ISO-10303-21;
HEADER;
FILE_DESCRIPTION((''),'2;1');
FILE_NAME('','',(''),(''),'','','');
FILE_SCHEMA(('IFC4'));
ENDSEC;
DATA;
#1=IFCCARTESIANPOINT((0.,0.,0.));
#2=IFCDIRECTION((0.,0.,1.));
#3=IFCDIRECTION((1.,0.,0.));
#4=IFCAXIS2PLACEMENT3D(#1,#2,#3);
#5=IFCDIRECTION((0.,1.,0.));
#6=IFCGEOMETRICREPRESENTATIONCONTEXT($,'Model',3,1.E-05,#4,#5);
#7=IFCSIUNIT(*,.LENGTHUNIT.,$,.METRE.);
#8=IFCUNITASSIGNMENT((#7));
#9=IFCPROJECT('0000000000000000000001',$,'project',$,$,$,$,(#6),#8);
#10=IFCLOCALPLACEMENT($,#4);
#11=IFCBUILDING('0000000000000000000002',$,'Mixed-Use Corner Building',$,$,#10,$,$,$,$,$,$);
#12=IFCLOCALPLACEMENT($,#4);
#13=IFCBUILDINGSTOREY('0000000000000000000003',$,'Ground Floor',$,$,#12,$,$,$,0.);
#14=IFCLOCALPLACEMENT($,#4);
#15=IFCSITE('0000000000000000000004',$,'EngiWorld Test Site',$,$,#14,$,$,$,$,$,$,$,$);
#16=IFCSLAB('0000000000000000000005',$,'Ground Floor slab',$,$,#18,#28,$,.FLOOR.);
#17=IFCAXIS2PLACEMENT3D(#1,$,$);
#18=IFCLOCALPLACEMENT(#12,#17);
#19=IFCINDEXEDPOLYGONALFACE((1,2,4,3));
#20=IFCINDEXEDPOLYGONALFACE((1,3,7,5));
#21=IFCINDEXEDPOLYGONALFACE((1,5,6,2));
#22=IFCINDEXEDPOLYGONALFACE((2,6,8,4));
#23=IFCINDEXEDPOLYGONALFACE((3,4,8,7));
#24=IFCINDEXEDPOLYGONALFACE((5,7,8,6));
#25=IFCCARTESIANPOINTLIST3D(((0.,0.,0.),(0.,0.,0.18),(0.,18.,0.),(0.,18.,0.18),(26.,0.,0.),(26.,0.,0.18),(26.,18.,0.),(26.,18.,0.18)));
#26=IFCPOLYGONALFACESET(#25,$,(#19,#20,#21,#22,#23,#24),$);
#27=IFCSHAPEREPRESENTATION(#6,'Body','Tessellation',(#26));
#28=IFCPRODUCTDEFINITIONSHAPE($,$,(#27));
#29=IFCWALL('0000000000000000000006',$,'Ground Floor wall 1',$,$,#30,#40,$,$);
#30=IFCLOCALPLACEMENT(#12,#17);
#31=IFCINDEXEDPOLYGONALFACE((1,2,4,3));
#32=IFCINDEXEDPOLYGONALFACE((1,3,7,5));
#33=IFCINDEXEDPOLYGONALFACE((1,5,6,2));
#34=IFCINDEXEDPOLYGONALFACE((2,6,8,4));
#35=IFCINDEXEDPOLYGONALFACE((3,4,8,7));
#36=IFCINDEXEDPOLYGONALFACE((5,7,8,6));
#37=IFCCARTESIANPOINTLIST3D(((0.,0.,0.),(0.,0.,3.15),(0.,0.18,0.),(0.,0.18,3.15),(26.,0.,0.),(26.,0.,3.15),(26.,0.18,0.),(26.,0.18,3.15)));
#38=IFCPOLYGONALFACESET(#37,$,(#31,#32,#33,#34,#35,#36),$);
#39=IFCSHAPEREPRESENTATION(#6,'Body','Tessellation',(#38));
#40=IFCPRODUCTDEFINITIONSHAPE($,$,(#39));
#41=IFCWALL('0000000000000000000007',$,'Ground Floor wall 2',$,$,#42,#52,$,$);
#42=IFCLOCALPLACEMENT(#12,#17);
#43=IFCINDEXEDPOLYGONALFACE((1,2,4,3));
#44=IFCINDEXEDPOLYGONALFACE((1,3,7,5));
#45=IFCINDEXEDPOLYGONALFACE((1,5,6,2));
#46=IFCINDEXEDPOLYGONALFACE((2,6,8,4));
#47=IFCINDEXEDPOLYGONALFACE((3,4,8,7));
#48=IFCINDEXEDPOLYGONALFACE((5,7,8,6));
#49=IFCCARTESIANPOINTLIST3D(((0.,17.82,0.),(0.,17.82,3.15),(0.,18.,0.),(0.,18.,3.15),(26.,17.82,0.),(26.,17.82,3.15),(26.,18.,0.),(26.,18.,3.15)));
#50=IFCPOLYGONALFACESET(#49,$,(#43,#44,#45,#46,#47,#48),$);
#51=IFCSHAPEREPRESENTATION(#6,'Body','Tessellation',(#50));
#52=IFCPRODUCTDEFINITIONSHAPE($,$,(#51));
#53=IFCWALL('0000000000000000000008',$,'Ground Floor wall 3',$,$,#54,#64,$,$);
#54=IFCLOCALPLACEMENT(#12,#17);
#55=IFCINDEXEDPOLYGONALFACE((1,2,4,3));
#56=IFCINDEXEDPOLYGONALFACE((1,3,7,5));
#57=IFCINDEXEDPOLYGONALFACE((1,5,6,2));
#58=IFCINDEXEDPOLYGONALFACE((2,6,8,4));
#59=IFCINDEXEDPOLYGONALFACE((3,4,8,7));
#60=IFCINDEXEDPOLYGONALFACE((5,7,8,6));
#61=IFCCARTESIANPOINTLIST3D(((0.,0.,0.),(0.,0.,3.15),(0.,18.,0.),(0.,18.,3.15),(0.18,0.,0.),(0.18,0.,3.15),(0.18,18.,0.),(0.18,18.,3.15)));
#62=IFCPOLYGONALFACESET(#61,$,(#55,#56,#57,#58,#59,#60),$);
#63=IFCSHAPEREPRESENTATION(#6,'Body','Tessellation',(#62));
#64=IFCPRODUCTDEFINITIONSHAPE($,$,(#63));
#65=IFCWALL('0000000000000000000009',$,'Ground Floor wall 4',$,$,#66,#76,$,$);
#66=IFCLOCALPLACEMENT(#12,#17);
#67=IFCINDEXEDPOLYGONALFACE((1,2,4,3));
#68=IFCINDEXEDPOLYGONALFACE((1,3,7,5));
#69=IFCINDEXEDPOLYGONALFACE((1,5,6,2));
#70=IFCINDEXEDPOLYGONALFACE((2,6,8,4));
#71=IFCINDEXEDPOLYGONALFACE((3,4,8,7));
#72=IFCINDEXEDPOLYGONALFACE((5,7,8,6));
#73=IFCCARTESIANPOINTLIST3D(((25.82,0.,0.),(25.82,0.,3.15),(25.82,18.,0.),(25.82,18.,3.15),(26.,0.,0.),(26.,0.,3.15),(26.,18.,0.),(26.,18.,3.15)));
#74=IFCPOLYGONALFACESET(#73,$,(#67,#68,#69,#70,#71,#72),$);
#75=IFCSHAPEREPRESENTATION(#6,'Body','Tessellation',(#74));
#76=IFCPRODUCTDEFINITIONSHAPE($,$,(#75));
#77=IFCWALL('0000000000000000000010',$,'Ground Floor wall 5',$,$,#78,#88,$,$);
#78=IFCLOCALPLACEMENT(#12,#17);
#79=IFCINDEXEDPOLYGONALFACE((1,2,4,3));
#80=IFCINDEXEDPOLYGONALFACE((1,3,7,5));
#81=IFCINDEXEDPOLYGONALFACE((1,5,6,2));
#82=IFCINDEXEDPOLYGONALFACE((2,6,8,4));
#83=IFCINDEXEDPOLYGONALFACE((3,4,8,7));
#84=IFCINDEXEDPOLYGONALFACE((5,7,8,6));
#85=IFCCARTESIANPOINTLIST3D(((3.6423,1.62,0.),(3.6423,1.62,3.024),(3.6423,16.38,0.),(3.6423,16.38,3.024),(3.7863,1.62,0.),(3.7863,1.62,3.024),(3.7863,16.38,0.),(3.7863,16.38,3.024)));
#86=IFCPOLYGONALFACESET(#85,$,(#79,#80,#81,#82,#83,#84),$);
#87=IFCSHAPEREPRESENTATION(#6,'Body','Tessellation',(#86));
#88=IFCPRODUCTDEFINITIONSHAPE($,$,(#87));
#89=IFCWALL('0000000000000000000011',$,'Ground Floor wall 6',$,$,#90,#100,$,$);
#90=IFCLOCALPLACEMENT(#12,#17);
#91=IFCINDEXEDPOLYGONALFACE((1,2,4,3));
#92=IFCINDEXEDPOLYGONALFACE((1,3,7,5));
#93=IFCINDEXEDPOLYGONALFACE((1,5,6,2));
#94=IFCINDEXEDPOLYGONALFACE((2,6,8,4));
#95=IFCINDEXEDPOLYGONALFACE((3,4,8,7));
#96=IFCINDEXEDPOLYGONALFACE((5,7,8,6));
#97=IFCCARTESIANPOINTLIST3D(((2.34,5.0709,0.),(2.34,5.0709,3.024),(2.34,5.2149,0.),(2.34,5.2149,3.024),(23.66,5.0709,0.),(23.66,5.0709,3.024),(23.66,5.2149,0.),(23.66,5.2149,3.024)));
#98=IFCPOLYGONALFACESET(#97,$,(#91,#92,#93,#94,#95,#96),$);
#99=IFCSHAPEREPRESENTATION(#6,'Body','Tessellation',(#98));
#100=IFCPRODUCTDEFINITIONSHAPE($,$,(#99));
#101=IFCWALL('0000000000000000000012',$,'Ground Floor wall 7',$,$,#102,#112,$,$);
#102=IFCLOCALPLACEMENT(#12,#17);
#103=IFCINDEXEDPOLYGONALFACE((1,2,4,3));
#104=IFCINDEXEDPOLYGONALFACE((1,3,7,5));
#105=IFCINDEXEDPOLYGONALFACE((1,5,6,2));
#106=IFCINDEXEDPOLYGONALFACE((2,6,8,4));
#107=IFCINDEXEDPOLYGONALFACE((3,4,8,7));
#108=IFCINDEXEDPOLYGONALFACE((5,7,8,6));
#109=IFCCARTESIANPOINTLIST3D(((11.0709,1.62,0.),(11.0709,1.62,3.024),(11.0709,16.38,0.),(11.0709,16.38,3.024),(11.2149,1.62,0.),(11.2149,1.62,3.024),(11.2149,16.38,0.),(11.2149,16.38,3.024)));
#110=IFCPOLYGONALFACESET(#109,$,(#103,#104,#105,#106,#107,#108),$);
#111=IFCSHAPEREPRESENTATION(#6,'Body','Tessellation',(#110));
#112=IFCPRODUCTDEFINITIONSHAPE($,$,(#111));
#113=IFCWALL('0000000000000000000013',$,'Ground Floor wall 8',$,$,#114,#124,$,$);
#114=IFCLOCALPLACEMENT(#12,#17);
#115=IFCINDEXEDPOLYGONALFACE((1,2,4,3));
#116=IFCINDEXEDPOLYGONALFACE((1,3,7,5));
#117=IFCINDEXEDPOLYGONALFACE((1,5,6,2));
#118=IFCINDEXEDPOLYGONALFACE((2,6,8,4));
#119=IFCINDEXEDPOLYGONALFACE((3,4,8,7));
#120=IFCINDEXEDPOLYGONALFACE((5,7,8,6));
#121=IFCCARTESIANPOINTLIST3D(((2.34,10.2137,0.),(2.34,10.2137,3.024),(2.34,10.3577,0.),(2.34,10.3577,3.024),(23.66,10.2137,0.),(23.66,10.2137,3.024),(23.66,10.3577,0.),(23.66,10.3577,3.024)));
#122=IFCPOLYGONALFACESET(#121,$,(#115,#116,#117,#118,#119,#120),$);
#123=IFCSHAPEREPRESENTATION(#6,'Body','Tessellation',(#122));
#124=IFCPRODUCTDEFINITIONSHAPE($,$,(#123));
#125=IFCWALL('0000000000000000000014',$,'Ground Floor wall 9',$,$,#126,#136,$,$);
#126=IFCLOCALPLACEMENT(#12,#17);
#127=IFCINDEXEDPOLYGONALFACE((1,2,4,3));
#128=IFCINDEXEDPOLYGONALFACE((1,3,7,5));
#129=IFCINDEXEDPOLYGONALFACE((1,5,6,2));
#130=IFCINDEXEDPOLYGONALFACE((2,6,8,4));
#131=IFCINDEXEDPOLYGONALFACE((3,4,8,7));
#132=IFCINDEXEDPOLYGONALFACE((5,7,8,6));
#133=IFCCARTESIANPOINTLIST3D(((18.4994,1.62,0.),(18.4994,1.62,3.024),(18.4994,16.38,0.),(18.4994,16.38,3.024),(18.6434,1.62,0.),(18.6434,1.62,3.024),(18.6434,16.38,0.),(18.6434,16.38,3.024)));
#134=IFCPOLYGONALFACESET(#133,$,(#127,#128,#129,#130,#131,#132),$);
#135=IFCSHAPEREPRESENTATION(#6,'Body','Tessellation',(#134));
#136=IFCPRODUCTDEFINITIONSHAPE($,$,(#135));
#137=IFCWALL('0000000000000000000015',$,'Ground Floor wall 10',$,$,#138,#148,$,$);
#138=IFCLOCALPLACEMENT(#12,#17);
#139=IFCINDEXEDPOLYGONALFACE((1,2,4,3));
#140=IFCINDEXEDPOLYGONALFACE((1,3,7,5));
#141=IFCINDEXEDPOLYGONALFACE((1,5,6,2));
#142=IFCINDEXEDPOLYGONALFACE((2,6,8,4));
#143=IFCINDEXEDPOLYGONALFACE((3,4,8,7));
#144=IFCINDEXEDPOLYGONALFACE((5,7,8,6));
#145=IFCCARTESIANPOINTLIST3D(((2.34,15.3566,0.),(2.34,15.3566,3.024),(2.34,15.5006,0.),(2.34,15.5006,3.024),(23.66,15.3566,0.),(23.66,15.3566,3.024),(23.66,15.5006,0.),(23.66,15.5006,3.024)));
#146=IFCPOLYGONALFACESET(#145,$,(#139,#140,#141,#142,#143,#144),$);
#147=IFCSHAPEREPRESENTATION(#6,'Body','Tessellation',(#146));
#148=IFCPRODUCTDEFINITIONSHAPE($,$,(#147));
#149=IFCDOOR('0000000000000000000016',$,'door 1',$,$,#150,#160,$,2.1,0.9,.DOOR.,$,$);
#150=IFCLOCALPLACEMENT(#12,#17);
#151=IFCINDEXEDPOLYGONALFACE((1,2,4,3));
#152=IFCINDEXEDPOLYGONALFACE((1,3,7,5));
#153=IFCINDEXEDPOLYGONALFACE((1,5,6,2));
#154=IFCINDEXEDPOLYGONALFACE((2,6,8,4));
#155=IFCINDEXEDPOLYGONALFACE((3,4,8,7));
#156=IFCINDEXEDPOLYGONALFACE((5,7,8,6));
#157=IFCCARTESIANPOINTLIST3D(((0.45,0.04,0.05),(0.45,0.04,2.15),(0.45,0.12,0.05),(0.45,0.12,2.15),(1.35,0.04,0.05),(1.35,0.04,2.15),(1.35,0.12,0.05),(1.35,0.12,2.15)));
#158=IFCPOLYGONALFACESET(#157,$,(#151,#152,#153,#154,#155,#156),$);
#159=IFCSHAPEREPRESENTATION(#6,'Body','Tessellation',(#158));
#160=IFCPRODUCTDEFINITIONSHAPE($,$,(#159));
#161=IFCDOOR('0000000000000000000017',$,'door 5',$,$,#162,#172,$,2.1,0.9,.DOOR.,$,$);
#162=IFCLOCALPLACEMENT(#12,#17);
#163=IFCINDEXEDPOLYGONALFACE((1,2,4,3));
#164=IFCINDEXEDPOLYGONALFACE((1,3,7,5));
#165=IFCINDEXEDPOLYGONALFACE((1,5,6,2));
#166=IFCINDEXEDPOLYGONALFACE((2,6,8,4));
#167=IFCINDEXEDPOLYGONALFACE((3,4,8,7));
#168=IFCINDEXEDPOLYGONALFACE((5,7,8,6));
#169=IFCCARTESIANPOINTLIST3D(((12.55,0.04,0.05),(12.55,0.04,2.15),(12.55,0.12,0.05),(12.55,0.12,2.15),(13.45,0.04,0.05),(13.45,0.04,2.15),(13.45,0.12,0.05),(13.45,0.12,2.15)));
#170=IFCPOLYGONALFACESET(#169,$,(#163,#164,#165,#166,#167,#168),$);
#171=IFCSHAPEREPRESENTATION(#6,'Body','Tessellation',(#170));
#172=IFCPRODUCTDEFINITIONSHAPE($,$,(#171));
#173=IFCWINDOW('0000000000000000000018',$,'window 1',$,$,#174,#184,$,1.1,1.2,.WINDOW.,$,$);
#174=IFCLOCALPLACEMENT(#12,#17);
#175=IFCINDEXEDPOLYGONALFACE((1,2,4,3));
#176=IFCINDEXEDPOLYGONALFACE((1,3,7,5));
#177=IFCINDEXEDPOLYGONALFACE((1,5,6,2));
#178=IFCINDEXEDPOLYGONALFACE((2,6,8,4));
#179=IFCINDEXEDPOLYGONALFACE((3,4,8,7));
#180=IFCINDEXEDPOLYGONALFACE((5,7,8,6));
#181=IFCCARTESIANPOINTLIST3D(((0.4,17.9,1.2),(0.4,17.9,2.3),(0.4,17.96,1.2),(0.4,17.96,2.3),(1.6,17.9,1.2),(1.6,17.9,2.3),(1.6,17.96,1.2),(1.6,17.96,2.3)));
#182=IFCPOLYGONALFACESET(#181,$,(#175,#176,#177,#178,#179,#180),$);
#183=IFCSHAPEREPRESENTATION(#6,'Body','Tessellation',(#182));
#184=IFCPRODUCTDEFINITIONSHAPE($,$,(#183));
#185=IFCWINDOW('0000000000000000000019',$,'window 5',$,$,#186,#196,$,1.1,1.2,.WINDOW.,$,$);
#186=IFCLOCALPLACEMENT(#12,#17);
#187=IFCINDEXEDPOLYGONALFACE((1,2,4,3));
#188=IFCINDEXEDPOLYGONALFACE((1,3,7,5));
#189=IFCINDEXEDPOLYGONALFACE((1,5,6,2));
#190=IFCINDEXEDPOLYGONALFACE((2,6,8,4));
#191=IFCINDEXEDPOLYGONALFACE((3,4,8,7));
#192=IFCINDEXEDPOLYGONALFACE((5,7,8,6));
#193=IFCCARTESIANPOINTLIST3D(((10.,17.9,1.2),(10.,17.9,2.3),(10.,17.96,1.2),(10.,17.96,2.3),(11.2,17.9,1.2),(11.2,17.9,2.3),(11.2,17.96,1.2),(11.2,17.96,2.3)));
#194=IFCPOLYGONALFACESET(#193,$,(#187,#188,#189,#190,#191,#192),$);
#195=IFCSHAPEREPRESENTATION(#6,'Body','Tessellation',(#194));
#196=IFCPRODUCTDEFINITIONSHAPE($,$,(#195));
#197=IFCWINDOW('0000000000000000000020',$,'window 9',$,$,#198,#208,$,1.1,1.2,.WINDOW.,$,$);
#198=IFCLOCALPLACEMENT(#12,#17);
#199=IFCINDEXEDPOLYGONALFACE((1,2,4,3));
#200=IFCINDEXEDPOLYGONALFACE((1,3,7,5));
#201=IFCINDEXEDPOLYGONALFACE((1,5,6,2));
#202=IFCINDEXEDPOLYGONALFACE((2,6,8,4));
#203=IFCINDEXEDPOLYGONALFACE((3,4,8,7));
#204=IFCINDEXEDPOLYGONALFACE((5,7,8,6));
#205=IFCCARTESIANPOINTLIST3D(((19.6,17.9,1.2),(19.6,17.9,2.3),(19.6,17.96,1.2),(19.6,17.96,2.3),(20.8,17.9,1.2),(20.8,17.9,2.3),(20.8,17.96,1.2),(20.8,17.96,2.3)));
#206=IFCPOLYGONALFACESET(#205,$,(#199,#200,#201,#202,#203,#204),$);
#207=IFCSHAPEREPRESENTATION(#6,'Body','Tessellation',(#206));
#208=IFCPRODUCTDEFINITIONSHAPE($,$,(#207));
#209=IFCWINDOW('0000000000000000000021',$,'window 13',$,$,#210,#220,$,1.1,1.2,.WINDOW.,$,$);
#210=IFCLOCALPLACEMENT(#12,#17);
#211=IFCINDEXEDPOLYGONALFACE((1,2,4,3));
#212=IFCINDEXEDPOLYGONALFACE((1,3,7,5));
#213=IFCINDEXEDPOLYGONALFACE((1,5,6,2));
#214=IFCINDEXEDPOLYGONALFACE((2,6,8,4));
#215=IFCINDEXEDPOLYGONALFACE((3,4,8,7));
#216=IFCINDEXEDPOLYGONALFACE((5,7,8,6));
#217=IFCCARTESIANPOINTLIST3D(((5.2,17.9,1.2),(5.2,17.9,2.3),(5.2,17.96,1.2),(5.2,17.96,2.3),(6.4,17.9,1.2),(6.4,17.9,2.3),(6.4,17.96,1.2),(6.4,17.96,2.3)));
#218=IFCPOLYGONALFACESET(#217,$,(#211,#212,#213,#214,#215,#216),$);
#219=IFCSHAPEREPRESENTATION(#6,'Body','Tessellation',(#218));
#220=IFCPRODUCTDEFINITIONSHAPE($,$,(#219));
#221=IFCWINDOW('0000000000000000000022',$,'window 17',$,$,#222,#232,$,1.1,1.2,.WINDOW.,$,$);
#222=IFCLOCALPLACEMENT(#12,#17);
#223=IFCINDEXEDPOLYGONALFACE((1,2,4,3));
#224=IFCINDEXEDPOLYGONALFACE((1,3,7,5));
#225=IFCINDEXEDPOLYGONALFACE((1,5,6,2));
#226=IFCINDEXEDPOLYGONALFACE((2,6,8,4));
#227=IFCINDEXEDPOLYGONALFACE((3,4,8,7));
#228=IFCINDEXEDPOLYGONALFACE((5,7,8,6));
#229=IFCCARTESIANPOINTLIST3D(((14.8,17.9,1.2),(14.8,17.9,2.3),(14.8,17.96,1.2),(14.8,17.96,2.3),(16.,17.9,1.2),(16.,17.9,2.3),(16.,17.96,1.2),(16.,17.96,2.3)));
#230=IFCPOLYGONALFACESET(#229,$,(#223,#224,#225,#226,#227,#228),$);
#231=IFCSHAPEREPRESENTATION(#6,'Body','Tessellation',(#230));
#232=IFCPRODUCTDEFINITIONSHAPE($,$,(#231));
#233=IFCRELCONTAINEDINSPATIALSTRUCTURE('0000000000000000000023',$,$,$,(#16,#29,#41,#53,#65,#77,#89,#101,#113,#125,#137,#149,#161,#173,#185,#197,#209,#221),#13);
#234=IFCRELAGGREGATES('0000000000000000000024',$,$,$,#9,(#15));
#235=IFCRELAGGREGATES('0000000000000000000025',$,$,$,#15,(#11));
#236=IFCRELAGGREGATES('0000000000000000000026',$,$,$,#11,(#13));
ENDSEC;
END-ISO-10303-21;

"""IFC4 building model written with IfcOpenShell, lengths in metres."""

from ifc_helpers import new_model, si_unit, direction, frame, origin_with_axes, origin_2d_with_axis, place, context, project, spatial, rectangle, extrude, element, save


model = new_model("IFC4")

# Units and contexts
model_context = context("Model", 3, precision=1e-05, world=origin_with_axes(), true_north=direction((0.0, 1.0, 0.0)))
ifc_project = project(units=[si_unit("LENGTHUNIT", "METRE")], contexts=[model_context])

# Site, building, storey
site_placement = place(None, origin_with_axes())
site = spatial("IfcSite", under=ifc_project, at=site_placement, Name="EngiWorld Test Site")
building_placement = place(None, origin_with_axes())
building = spatial("IfcBuilding", under=site, at=building_placement, Name="Mixed-Use Corner Building")
storey_placement = place(None, origin_with_axes())
storey = spatial("IfcBuildingStorey", under=building, at=storey_placement, Name="Ground Floor", Elevation=0.0)

# Slab
slab_placement = place(None, frame((13.0, 9.0, 0.0), z_axis=(0.0, 0.0, 1.0), x_axis=(1.0, 0.0, 0.0)))
element("IfcSlab", 1, at=slab_placement, inside=storey, Name="Ground Floor slab", PredefinedType="FLOOR", context=model_context, shape_type="SweptSolid", body=[
    extrude(rectangle(XDim=26.0, YDim=18.0, at=origin_2d_with_axis()), origin_with_axes(), (0.0, 0.0, 1.0), 0.18),
])

# Walls
for number, where, z_axis, x_axis, name in (
    (2, (13.0, 0.09, 0.0), (0.0, 0.0, 1.0), (1.0, 0.0, 0.0), "Ground Floor wall 1"),
    (3, (13.0, 17.91, 0.0), (0.0, 0.0, 1.0), (1.0, 0.0, 0.0), "Ground Floor wall 2"),
):
    element("IfcWall", number, at=place(None, frame(where, z_axis=z_axis, x_axis=x_axis)), inside=storey, Name=name, context=model_context, shape_type="SweptSolid", body=[
        extrude(rectangle(XDim=26.0, YDim=0.18, at=origin_2d_with_axis()), origin_with_axes(), (0.0, 0.0, 1.0), 3.15),
    ])
for number, where, z_axis, x_axis, name in (
    (4, (0.09, 9.0, 0.0), (0.0, 0.0, 1.0), (1.0, 0.0, 0.0), "Ground Floor wall 3"),
    (5, (25.91, 9.0, 0.0), (0.0, 0.0, 1.0), (1.0, 0.0, 0.0), "Ground Floor wall 4"),
):
    element("IfcWall", number, at=place(None, frame(where, z_axis=z_axis, x_axis=x_axis)), inside=storey, Name=name, context=model_context, shape_type="SweptSolid", body=[
        extrude(rectangle(XDim=0.18, YDim=18.0, at=origin_2d_with_axis()), origin_with_axes(), (0.0, 0.0, 1.0), 3.15),
    ])
wall_1_placement = place(None, frame((3.7143, 9.0, 0.0), z_axis=(0.0, 0.0, 1.0), x_axis=(1.0, 0.0, 0.0)))
element("IfcWall", 6, at=wall_1_placement, inside=storey, Name="Ground Floor wall 5", context=model_context, shape_type="SweptSolid", body=[
    extrude(rectangle(XDim=0.144, YDim=14.76, at=origin_2d_with_axis()), origin_with_axes(), (0.0, 0.0, 1.0), 3.024),
])
wall_2_placement = place(None, frame((13.0, 5.1429, 0.0), z_axis=(0.0, 0.0, 1.0), x_axis=(1.0, 0.0, 0.0)))
element("IfcWall", 7, at=wall_2_placement, inside=storey, Name="Ground Floor wall 6", context=model_context, shape_type="SweptSolid", body=[
    extrude(rectangle(XDim=21.32, YDim=0.144, at=origin_2d_with_axis()), origin_with_axes(), (0.0, 0.0, 1.0), 3.024),
])
wall_3_placement = place(None, frame((11.1429, 9.0, 0.0), z_axis=(0.0, 0.0, 1.0), x_axis=(1.0, 0.0, 0.0)))
element("IfcWall", 8, at=wall_3_placement, inside=storey, Name="Ground Floor wall 7", context=model_context, shape_type="SweptSolid", body=[
    extrude(rectangle(XDim=0.144, YDim=14.76, at=origin_2d_with_axis()), origin_with_axes(), (0.0, 0.0, 1.0), 3.024),
])
wall_4_placement = place(None, frame((13.0, 10.2857, 0.0), z_axis=(0.0, 0.0, 1.0), x_axis=(1.0, 0.0, 0.0)))
element("IfcWall", 9, at=wall_4_placement, inside=storey, Name="Ground Floor wall 8", context=model_context, shape_type="SweptSolid", body=[
    extrude(rectangle(XDim=21.32, YDim=0.144, at=origin_2d_with_axis()), origin_with_axes(), (0.0, 0.0, 1.0), 3.024),
])
wall_5_placement = place(None, frame((18.5714, 9.0, 0.0), z_axis=(0.0, 0.0, 1.0), x_axis=(1.0, 0.0, 0.0)))
element("IfcWall", 10, at=wall_5_placement, inside=storey, Name="Ground Floor wall 9", context=model_context, shape_type="SweptSolid", body=[
    extrude(rectangle(XDim=0.144, YDim=14.76, at=origin_2d_with_axis()), origin_with_axes(), (0.0, 0.0, 1.0), 3.024),
])
wall_6_placement = place(None, frame((13.0, 15.4286, 0.0), z_axis=(0.0, 0.0, 1.0), x_axis=(1.0, 0.0, 0.0)))
element("IfcWall", 11, at=wall_6_placement, inside=storey, Name="Ground Floor wall 10", context=model_context, shape_type="SweptSolid", body=[
    extrude(rectangle(XDim=21.32, YDim=0.144, at=origin_2d_with_axis()), origin_with_axes(), (0.0, 0.0, 1.0), 3.024),
])

# Doors
for number, where, z_axis, x_axis, name in (
    (12, (0.9, 0.08, 0.05), (0.0, 0.0, 1.0), (1.0, 0.0, 0.0), "door 1"),
    (13, (13.0, 0.08, 0.05), (0.0, 0.0, 1.0), (1.0, 0.0, 0.0), "door 5"),
):
    element("IfcDoor", number, at=place(None, frame(where, z_axis=z_axis, x_axis=x_axis)), inside=storey, Name=name, OverallHeight=2.1, OverallWidth=0.9, PredefinedType="DOOR", context=model_context, shape_type="SweptSolid", body=[
        extrude(rectangle(XDim=0.9, YDim=0.08, at=origin_2d_with_axis()), origin_with_axes(), (0.0, 0.0, 1.0), 2.1),
    ])

# Windows
for number, where, z_axis, x_axis, name in (
    (14, (1.0, 17.93, 1.2), (0.0, 0.0, 1.0), (1.0, 0.0, 0.0), "window 1"),
    (15, (10.6, 17.93, 1.2), (0.0, 0.0, 1.0), (1.0, 0.0, 0.0), "window 5"),
    (16, (20.2, 17.93, 1.2), (0.0, 0.0, 1.0), (1.0, 0.0, 0.0), "window 9"),
    (17, (5.8, 17.93, 1.2), (0.0, 0.0, 1.0), (1.0, 0.0, 0.0), "window 13"),
    (18, (15.4, 17.93, 1.2), (0.0, 0.0, 1.0), (1.0, 0.0, 0.0), "window 17"),
):
    element("IfcWindow", number, at=place(None, frame(where, z_axis=z_axis, x_axis=x_axis)), inside=storey, Name=name, OverallHeight=1.1, OverallWidth=1.2, PredefinedType="WINDOW", context=model_context, shape_type="SweptSolid", body=[
        extrude(rectangle(XDim=1.2, YDim=0.06, at=origin_2d_with_axis()), origin_with_axes(), (0.0, 0.0, 1.0), 1.1),
    ])

save(model, "model.ifc")
